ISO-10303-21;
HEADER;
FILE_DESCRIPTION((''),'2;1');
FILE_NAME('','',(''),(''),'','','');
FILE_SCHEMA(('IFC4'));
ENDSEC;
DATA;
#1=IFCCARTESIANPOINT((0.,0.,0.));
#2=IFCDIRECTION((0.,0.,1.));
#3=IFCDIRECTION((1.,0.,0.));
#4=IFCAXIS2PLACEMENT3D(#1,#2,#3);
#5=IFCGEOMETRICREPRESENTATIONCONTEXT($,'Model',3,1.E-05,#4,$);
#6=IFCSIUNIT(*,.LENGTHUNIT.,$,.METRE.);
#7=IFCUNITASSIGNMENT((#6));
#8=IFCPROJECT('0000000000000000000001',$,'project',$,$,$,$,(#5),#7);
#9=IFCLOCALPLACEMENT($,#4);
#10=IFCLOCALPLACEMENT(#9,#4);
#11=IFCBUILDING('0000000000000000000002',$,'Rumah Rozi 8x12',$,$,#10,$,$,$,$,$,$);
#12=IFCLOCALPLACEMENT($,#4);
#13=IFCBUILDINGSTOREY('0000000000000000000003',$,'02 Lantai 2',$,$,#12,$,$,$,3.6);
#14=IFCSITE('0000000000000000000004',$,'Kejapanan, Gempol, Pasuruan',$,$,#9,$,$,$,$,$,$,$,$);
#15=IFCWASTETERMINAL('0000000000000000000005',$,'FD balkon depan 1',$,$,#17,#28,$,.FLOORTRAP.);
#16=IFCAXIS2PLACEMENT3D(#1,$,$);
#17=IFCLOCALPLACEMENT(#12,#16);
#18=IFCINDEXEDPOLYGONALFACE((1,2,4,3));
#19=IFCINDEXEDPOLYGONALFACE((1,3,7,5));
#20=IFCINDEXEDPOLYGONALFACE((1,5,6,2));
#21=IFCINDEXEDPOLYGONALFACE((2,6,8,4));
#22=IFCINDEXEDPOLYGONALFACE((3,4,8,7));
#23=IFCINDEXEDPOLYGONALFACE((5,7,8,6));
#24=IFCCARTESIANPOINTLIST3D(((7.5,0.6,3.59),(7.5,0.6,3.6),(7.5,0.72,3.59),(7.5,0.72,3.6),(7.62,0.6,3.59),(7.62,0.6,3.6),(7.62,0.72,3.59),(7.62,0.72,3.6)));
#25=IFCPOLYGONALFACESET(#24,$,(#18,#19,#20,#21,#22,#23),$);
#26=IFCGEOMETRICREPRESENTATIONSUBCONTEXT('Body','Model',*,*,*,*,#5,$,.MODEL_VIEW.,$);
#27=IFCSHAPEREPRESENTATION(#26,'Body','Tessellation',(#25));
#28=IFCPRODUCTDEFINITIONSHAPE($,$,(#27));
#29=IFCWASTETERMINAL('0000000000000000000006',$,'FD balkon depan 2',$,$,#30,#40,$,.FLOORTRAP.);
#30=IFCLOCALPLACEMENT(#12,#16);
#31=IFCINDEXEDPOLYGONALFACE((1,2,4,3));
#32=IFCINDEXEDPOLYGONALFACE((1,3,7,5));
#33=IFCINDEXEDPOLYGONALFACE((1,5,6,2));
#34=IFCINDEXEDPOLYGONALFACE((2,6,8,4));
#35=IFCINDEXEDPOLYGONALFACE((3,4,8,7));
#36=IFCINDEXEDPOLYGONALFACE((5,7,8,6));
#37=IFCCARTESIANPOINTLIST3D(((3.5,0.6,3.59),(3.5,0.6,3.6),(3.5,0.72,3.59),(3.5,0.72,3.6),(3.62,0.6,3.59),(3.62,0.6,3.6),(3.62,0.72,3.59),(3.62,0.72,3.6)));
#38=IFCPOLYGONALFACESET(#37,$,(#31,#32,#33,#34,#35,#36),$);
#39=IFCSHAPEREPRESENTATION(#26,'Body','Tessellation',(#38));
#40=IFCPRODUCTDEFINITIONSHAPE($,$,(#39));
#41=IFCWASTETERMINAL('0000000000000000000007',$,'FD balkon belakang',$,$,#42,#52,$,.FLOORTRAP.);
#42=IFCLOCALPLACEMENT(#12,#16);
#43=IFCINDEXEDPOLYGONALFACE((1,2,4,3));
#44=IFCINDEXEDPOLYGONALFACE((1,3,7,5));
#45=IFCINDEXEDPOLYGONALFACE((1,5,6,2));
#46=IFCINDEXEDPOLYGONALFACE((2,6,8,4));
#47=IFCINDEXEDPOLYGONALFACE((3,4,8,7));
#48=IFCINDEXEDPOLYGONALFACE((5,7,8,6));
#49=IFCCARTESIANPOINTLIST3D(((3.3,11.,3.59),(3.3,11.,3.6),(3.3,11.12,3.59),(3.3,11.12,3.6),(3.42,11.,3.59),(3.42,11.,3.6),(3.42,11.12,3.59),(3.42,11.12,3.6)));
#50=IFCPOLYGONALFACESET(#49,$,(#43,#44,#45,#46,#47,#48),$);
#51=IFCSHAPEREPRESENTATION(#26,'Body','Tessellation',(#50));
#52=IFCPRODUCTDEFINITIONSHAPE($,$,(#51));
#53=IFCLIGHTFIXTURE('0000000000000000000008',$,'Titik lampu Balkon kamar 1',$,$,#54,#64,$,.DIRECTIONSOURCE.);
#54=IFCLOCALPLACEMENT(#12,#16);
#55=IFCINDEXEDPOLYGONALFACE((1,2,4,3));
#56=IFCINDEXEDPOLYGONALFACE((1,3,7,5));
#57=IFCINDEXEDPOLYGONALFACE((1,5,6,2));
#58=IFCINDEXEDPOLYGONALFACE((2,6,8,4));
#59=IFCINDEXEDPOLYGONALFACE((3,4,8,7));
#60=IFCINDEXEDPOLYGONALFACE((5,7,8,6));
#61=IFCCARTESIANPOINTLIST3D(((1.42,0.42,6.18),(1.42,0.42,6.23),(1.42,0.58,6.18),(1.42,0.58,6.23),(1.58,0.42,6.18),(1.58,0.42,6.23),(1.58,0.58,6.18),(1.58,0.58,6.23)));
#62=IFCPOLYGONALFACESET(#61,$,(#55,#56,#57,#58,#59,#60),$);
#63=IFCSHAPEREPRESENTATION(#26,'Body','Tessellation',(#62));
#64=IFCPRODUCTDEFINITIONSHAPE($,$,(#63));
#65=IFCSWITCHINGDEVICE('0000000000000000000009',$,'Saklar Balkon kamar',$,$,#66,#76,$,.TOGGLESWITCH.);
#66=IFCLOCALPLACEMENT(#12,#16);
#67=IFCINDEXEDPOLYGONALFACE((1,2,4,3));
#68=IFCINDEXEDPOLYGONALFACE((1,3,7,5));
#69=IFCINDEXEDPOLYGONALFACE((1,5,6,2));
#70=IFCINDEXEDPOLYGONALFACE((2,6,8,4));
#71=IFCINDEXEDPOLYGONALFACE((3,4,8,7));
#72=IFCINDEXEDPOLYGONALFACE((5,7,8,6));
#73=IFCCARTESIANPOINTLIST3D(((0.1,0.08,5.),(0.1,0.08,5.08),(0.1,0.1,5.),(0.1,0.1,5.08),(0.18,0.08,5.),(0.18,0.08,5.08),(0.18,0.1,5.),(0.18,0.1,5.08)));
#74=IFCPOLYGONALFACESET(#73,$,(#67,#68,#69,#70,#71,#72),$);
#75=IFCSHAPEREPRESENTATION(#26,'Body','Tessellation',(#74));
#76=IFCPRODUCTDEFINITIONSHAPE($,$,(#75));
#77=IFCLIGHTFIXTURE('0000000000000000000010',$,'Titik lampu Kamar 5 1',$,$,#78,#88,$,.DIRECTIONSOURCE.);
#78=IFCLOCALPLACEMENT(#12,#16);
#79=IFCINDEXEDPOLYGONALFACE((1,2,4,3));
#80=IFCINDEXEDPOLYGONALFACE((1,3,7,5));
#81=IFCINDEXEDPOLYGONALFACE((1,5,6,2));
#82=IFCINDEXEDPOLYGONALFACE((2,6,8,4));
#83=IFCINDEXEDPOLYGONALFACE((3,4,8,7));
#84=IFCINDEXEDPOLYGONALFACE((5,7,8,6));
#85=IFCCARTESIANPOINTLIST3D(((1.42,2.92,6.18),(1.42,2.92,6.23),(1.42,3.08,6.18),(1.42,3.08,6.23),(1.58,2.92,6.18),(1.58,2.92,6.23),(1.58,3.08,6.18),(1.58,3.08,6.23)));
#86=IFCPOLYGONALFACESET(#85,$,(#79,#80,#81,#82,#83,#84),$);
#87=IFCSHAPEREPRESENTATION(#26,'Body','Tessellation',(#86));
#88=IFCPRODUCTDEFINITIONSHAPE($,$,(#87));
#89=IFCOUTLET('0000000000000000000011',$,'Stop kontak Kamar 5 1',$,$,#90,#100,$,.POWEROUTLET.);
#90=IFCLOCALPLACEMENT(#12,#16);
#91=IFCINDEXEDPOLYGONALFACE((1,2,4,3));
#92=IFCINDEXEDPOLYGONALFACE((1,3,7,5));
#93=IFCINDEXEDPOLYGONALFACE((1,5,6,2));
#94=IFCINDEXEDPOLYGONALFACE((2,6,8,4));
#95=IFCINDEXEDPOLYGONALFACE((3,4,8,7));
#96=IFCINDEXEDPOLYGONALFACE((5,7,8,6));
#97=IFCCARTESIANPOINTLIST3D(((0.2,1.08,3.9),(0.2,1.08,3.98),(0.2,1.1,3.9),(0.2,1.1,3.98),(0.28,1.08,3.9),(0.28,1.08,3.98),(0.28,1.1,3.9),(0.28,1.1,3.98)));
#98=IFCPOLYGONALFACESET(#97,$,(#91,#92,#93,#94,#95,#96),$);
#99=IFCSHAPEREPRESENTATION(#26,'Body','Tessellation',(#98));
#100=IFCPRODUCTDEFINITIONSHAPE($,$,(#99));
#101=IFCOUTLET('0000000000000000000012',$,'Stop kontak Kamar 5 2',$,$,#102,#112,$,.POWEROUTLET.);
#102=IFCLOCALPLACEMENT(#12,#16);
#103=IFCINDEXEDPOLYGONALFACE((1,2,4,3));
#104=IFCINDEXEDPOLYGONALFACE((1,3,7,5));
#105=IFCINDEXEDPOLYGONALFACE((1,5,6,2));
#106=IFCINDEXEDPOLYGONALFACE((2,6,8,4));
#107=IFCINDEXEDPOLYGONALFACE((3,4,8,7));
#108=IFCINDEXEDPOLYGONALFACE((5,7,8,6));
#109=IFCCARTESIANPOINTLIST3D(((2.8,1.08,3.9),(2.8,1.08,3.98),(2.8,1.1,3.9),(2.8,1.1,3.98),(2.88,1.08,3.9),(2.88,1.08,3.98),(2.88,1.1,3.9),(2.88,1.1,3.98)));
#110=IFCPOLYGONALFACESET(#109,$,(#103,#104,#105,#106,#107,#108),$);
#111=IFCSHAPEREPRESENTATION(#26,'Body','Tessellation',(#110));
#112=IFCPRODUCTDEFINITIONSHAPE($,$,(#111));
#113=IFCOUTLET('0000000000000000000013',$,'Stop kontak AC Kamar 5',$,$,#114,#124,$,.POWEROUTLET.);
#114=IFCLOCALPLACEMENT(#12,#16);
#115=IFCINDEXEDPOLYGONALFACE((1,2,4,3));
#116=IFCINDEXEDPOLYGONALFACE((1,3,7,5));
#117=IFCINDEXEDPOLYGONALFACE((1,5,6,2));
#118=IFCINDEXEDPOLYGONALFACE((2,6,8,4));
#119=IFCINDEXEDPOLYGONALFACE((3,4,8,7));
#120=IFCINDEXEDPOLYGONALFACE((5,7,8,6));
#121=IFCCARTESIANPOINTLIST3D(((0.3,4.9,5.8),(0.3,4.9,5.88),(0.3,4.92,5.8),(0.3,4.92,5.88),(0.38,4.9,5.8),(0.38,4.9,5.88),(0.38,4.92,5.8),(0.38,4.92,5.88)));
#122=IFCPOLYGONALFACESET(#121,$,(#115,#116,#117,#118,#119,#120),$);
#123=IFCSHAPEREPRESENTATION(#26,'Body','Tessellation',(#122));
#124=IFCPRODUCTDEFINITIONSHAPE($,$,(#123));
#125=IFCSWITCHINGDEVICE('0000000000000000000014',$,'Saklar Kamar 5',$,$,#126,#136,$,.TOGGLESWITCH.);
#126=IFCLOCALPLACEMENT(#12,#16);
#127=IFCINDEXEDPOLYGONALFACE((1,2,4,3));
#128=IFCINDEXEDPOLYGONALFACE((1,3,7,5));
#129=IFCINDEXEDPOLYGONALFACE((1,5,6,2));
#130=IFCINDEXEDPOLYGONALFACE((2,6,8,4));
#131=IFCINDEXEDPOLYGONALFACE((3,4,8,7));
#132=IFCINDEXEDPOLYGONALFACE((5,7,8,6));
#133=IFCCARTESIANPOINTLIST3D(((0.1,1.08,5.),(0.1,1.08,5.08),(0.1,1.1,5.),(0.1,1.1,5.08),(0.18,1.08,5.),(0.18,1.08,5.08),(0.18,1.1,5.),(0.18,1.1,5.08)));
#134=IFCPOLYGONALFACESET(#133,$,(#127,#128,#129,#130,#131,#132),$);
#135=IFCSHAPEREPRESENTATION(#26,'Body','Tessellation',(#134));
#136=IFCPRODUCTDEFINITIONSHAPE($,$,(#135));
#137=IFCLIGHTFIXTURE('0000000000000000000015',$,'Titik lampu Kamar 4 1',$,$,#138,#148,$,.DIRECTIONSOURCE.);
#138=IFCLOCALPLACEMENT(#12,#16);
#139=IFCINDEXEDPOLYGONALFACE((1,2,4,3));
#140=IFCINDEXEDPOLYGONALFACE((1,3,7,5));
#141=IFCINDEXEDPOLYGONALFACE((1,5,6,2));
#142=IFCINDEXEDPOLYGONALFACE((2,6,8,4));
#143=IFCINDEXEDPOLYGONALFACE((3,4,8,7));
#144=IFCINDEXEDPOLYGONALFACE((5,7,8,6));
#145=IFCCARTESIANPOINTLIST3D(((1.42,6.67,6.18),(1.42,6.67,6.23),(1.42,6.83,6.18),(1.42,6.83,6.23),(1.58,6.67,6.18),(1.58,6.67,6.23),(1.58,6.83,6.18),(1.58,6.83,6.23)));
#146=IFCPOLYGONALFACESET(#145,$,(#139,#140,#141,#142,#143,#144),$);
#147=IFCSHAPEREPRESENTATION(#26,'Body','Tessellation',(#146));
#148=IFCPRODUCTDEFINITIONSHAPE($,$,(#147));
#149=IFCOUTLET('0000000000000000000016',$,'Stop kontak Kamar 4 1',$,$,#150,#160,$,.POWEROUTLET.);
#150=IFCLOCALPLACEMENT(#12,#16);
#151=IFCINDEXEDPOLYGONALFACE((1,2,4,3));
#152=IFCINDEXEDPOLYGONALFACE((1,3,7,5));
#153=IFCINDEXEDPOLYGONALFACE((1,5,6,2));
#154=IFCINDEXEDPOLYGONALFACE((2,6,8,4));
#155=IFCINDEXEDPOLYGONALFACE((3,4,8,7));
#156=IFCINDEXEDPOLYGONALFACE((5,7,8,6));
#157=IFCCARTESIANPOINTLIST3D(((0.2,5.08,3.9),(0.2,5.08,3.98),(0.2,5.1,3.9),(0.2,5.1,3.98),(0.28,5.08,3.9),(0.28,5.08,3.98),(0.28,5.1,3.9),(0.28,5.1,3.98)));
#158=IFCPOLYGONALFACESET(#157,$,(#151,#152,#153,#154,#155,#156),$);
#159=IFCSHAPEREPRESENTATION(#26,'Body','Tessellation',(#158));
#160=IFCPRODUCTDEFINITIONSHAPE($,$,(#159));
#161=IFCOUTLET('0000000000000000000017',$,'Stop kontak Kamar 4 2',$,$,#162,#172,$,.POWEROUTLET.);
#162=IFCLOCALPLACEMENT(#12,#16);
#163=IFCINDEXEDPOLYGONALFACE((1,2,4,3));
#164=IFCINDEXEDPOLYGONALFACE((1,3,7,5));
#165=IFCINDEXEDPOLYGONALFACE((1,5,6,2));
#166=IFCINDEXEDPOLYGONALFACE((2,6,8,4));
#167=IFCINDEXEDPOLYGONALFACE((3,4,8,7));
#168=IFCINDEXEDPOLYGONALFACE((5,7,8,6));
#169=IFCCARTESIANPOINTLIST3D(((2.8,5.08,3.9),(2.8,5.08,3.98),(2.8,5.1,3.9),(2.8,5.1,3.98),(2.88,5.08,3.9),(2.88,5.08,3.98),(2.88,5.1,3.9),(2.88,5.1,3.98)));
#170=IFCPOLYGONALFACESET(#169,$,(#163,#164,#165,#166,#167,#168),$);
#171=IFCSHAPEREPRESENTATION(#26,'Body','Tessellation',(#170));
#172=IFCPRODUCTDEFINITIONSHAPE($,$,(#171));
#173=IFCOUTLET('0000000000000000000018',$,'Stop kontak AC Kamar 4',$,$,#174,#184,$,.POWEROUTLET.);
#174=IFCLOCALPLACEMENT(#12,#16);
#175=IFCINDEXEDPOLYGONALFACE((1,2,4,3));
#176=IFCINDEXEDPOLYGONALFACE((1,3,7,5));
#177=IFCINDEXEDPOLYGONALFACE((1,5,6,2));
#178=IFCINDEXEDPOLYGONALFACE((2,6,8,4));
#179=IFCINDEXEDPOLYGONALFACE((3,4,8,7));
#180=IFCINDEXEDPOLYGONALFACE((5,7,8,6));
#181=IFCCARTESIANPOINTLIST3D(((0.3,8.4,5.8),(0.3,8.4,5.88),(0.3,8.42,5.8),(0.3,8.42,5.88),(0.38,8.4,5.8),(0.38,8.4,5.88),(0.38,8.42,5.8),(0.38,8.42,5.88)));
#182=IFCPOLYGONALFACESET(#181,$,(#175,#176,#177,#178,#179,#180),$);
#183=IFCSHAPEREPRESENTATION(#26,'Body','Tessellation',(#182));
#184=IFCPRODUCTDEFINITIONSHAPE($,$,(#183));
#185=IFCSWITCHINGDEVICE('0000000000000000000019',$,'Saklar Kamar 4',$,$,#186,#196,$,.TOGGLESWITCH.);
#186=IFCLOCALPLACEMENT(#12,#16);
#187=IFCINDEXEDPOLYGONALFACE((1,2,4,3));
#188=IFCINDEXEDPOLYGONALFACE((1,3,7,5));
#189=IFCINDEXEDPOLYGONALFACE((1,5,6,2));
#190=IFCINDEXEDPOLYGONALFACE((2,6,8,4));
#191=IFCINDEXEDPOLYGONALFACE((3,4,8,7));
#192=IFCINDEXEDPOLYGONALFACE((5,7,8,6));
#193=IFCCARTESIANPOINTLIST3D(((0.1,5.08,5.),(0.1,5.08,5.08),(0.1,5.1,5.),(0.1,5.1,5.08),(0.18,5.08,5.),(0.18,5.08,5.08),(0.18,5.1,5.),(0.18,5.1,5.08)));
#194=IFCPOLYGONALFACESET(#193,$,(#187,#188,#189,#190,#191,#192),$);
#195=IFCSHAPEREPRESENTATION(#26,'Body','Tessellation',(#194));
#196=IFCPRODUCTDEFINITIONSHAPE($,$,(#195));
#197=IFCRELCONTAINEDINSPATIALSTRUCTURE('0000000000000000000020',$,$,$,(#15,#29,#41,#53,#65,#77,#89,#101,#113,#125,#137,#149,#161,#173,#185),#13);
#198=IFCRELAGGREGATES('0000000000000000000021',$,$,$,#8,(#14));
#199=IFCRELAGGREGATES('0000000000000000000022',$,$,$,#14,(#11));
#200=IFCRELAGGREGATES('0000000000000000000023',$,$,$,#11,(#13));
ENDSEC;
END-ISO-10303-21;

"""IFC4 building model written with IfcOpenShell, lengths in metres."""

from ifc_helpers import new_model, si_unit, frame, origin_with_axes, place, context, subcontext, project, spatial, line, indexed_curve, outline, extrude, element, save


model = new_model("IFC4")

# Units and contexts
model_context = context("Model", 3, precision=1e-05, world=origin_with_axes())
body_context = subcontext(model_context, "Body", "Model", "MODEL_VIEW")
ifc_project = project(units=[si_unit("LENGTHUNIT", "METRE")], contexts=[model_context])

# Site, building, storey
site_placement = place(None, origin_with_axes())
site = spatial("IfcSite", under=ifc_project, at=site_placement, Name="Kejapanan, Gempol, Pasuruan")
building_placement = place(site_placement, origin_with_axes())
building = spatial("IfcBuilding", under=site, at=building_placement, Name="Rumah Rozi 8x12")
storey_placement = place(None, origin_with_axes())
storey = spatial("IfcBuildingStorey", under=building, at=storey_placement, Name="02 Lantai 2", Elevation=3.6)

# Waste terminals
waste_terminal_1_placement = place(storey_placement, origin_with_axes())
element("IfcWasteTerminal", 1, at=waste_terminal_1_placement, inside=storey, Name="FD balkon depan 1", PredefinedType="FLOORTRAP", context=body_context, shape_type="SweptSolid", body=[
    extrude(outline(indexed_curve([(7.5, 0.6), (7.62, 0.6), (7.62, 0.72), (7.5, 0.72)], segments=[line(1, 2, 3, 4, 1)])), frame((0.0, 0.0, 3.59), z_axis=(0.0, 0.0, 1.0), x_axis=(1.0, 0.0, 0.0)), (0.0, 0.0, 1.0), 0.01),
])
waste_terminal_2_placement = place(storey_placement, origin_with_axes())
element("IfcWasteTerminal", 2, at=waste_terminal_2_placement, inside=storey, Name="FD balkon depan 2", PredefinedType="FLOORTRAP", context=body_context, shape_type="SweptSolid", body=[
    extrude(outline(indexed_curve([(3.5, 0.6), (3.62, 0.6), (3.62, 0.72), (3.5, 0.72)], segments=[line(1, 2, 3, 4, 1)])), frame((0.0, 0.0, 3.59), z_axis=(0.0, 0.0, 1.0), x_axis=(1.0, 0.0, 0.0)), (0.0, 0.0, 1.0), 0.01),
])
waste_terminal_3_placement = place(storey_placement, origin_with_axes())
element("IfcWasteTerminal", 3, at=waste_terminal_3_placement, inside=storey, Name="FD balkon belakang", PredefinedType="FLOORTRAP", context=body_context, shape_type="SweptSolid", body=[
    extrude(outline(indexed_curve([(3.3, 11.0), (3.42, 11.0), (3.42, 11.12), (3.3, 11.12)], segments=[line(1, 2, 3, 4, 1)])), frame((0.0, 0.0, 3.59), z_axis=(0.0, 0.0, 1.0), x_axis=(1.0, 0.0, 0.0)), (0.0, 0.0, 1.0), 0.01),
])

# Light fixture
light_fixture_1_placement = place(storey_placement, origin_with_axes())
element("IfcLightFixture", 4, at=light_fixture_1_placement, inside=storey, Name="Titik lampu Balkon kamar 1", PredefinedType="DIRECTIONSOURCE", context=body_context, shape_type="SweptSolid", body=[
    extrude(outline(indexed_curve([(1.42, 0.42), (1.58, 0.42), (1.58, 0.58), (1.42, 0.58)], segments=[line(1, 2, 3, 4, 1)])), frame((0.0, 0.0, 6.18), z_axis=(0.0, 0.0, 1.0), x_axis=(1.0, 0.0, 0.0)), (0.0, 0.0, 1.0), 0.05),
])

# Switching device
switching_device_1_placement = place(storey_placement, origin_with_axes())
element("IfcSwitchingDevice", 5, at=switching_device_1_placement, inside=storey, Name="Saklar Balkon kamar", PredefinedType="TOGGLESWITCH", context=body_context, shape_type="SweptSolid", body=[
    extrude(outline(indexed_curve([(0.1, 0.08), (0.18, 0.08), (0.18, 0.1), (0.1, 0.1)], segments=[line(1, 2, 3, 4, 1)])), frame((0.0, 0.0, 5.0), z_axis=(0.0, 0.0, 1.0), x_axis=(1.0, 0.0, 0.0)), (0.0, 0.0, 1.0), 0.08),
])

# Light fixture
light_fixture_2_placement = place(storey_placement, origin_with_axes())
element("IfcLightFixture", 6, at=light_fixture_2_placement, inside=storey, Name="Titik lampu Kamar 5 1", PredefinedType="DIRECTIONSOURCE", context=body_context, shape_type="SweptSolid", body=[
    extrude(outline(indexed_curve([(1.42, 2.92), (1.58, 2.92), (1.58, 3.08), (1.42, 3.08)], segments=[line(1, 2, 3, 4, 1)])), frame((0.0, 0.0, 6.18), z_axis=(0.0, 0.0, 1.0), x_axis=(1.0, 0.0, 0.0)), (0.0, 0.0, 1.0), 0.05),
])

# Outlets
outlet_1_placement = place(storey_placement, origin_with_axes())
element("IfcOutlet", 7, at=outlet_1_placement, inside=storey, Name="Stop kontak Kamar 5 1", PredefinedType="POWEROUTLET", context=body_context, shape_type="SweptSolid", body=[
    extrude(outline(indexed_curve([(0.2, 1.08), (0.28, 1.08), (0.28, 1.1), (0.2, 1.1)], segments=[line(1, 2, 3, 4, 1)])), frame((0.0, 0.0, 3.9), z_axis=(0.0, 0.0, 1.0), x_axis=(1.0, 0.0, 0.0)), (0.0, 0.0, 1.0), 0.08),
])
outlet_2_placement = place(storey_placement, origin_with_axes())
element("IfcOutlet", 8, at=outlet_2_placement, inside=storey, Name="Stop kontak Kamar 5 2", PredefinedType="POWEROUTLET", context=body_context, shape_type="SweptSolid", body=[
    extrude(outline(indexed_curve([(2.8, 1.08), (2.88, 1.08), (2.88, 1.1), (2.8, 1.1)], segments=[line(1, 2, 3, 4, 1)])), frame((0.0, 0.0, 3.9), z_axis=(0.0, 0.0, 1.0), x_axis=(1.0, 0.0, 0.0)), (0.0, 0.0, 1.0), 0.08),
])
outlet_3_placement = place(storey_placement, origin_with_axes())
element("IfcOutlet", 9, at=outlet_3_placement, inside=storey, Name="Stop kontak AC Kamar 5", PredefinedType="POWEROUTLET", context=body_context, shape_type="SweptSolid", body=[
    extrude(outline(indexed_curve([(0.3, 4.9), (0.38, 4.9), (0.38, 4.92), (0.3, 4.92)], segments=[line(1, 2, 3, 4, 1)])), frame((0.0, 0.0, 5.8), z_axis=(0.0, 0.0, 1.0), x_axis=(1.0, 0.0, 0.0)), (0.0, 0.0, 1.0), 0.08),
])

# Switching device
switching_device_2_placement = place(storey_placement, origin_with_axes())
element("IfcSwitchingDevice", 10, at=switching_device_2_placement, inside=storey, Name="Saklar Kamar 5", PredefinedType="TOGGLESWITCH", context=body_context, shape_type="SweptSolid", body=[
    extrude(outline(indexed_curve([(0.1, 1.08), (0.18, 1.08), (0.18, 1.1), (0.1, 1.1)], segments=[line(1, 2, 3, 4, 1)])), frame((0.0, 0.0, 5.0), z_axis=(0.0, 0.0, 1.0), x_axis=(1.0, 0.0, 0.0)), (0.0, 0.0, 1.0), 0.08),
])

# Light fixture
light_fixture_3_placement = place(storey_placement, origin_with_axes())
element("IfcLightFixture", 11, at=light_fixture_3_placement, inside=storey, Name="Titik lampu Kamar 4 1", PredefinedType="DIRECTIONSOURCE", context=body_context, shape_type="SweptSolid", body=[
    extrude(outline(indexed_curve([(1.42, 6.67), (1.58, 6.67), (1.58, 6.83), (1.42, 6.83)], segments=[line(1, 2, 3, 4, 1)])), frame((0.0, 0.0, 6.18), z_axis=(0.0, 0.0, 1.0), x_axis=(1.0, 0.0, 0.0)), (0.0, 0.0, 1.0), 0.05),
])

# Outlets
outlet_4_placement = place(storey_placement, origin_with_axes())
element("IfcOutlet", 12, at=outlet_4_placement, inside=storey, Name="Stop kontak Kamar 4 1", PredefinedType="POWEROUTLET", context=body_context, shape_type="SweptSolid", body=[
    extrude(outline(indexed_curve([(0.2, 5.08), (0.28, 5.08), (0.28, 5.1), (0.2, 5.1)], segments=[line(1, 2, 3, 4, 1)])), frame((0.0, 0.0, 3.9), z_axis=(0.0, 0.0, 1.0), x_axis=(1.0, 0.0, 0.0)), (0.0, 0.0, 1.0), 0.08),
])
outlet_5_placement = place(storey_placement, origin_with_axes())
element("IfcOutlet", 13, at=outlet_5_placement, inside=storey, Name="Stop kontak Kamar 4 2", PredefinedType="POWEROUTLET", context=body_context, shape_type="SweptSolid", body=[
    extrude(outline(indexed_curve([(2.8, 5.08), (2.88, 5.08), (2.88, 5.1), (2.8, 5.1)], segments=[line(1, 2, 3, 4, 1)])), frame((0.0, 0.0, 3.9), z_axis=(0.0, 0.0, 1.0), x_axis=(1.0, 0.0, 0.0)), (0.0, 0.0, 1.0), 0.08),
])
outlet_6_placement = place(storey_placement, origin_with_axes())
element("IfcOutlet", 14, at=outlet_6_placement, inside=storey, Name="Stop kontak AC Kamar 4", PredefinedType="POWEROUTLET", context=body_context, shape_type="SweptSolid", body=[
    extrude(outline(indexed_curve([(0.3, 8.4), (0.38, 8.4), (0.38, 8.42), (0.3, 8.42)], segments=[line(1, 2, 3, 4, 1)])), frame((0.0, 0.0, 5.8), z_axis=(0.0, 0.0, 1.0), x_axis=(1.0, 0.0, 0.0)), (0.0, 0.0, 1.0), 0.08),
])

# Switching device
switching_device_3_placement = place(storey_placement, origin_with_axes())
element("IfcSwitchingDevice", 15, at=switching_device_3_placement, inside=storey, Name="Saklar Kamar 4", PredefinedType="TOGGLESWITCH", context=body_context, shape_type="SweptSolid", body=[
    extrude(outline(indexed_curve([(0.1, 5.08), (0.18, 5.08), (0.18, 5.1), (0.1, 5.1)], segments=[line(1, 2, 3, 4, 1)])), frame((0.0, 0.0, 5.0), z_axis=(0.0, 0.0, 1.0), x_axis=(1.0, 0.0, 0.0)), (0.0, 0.0, 1.0), 0.08),
])

save(model, "model.ifc")
